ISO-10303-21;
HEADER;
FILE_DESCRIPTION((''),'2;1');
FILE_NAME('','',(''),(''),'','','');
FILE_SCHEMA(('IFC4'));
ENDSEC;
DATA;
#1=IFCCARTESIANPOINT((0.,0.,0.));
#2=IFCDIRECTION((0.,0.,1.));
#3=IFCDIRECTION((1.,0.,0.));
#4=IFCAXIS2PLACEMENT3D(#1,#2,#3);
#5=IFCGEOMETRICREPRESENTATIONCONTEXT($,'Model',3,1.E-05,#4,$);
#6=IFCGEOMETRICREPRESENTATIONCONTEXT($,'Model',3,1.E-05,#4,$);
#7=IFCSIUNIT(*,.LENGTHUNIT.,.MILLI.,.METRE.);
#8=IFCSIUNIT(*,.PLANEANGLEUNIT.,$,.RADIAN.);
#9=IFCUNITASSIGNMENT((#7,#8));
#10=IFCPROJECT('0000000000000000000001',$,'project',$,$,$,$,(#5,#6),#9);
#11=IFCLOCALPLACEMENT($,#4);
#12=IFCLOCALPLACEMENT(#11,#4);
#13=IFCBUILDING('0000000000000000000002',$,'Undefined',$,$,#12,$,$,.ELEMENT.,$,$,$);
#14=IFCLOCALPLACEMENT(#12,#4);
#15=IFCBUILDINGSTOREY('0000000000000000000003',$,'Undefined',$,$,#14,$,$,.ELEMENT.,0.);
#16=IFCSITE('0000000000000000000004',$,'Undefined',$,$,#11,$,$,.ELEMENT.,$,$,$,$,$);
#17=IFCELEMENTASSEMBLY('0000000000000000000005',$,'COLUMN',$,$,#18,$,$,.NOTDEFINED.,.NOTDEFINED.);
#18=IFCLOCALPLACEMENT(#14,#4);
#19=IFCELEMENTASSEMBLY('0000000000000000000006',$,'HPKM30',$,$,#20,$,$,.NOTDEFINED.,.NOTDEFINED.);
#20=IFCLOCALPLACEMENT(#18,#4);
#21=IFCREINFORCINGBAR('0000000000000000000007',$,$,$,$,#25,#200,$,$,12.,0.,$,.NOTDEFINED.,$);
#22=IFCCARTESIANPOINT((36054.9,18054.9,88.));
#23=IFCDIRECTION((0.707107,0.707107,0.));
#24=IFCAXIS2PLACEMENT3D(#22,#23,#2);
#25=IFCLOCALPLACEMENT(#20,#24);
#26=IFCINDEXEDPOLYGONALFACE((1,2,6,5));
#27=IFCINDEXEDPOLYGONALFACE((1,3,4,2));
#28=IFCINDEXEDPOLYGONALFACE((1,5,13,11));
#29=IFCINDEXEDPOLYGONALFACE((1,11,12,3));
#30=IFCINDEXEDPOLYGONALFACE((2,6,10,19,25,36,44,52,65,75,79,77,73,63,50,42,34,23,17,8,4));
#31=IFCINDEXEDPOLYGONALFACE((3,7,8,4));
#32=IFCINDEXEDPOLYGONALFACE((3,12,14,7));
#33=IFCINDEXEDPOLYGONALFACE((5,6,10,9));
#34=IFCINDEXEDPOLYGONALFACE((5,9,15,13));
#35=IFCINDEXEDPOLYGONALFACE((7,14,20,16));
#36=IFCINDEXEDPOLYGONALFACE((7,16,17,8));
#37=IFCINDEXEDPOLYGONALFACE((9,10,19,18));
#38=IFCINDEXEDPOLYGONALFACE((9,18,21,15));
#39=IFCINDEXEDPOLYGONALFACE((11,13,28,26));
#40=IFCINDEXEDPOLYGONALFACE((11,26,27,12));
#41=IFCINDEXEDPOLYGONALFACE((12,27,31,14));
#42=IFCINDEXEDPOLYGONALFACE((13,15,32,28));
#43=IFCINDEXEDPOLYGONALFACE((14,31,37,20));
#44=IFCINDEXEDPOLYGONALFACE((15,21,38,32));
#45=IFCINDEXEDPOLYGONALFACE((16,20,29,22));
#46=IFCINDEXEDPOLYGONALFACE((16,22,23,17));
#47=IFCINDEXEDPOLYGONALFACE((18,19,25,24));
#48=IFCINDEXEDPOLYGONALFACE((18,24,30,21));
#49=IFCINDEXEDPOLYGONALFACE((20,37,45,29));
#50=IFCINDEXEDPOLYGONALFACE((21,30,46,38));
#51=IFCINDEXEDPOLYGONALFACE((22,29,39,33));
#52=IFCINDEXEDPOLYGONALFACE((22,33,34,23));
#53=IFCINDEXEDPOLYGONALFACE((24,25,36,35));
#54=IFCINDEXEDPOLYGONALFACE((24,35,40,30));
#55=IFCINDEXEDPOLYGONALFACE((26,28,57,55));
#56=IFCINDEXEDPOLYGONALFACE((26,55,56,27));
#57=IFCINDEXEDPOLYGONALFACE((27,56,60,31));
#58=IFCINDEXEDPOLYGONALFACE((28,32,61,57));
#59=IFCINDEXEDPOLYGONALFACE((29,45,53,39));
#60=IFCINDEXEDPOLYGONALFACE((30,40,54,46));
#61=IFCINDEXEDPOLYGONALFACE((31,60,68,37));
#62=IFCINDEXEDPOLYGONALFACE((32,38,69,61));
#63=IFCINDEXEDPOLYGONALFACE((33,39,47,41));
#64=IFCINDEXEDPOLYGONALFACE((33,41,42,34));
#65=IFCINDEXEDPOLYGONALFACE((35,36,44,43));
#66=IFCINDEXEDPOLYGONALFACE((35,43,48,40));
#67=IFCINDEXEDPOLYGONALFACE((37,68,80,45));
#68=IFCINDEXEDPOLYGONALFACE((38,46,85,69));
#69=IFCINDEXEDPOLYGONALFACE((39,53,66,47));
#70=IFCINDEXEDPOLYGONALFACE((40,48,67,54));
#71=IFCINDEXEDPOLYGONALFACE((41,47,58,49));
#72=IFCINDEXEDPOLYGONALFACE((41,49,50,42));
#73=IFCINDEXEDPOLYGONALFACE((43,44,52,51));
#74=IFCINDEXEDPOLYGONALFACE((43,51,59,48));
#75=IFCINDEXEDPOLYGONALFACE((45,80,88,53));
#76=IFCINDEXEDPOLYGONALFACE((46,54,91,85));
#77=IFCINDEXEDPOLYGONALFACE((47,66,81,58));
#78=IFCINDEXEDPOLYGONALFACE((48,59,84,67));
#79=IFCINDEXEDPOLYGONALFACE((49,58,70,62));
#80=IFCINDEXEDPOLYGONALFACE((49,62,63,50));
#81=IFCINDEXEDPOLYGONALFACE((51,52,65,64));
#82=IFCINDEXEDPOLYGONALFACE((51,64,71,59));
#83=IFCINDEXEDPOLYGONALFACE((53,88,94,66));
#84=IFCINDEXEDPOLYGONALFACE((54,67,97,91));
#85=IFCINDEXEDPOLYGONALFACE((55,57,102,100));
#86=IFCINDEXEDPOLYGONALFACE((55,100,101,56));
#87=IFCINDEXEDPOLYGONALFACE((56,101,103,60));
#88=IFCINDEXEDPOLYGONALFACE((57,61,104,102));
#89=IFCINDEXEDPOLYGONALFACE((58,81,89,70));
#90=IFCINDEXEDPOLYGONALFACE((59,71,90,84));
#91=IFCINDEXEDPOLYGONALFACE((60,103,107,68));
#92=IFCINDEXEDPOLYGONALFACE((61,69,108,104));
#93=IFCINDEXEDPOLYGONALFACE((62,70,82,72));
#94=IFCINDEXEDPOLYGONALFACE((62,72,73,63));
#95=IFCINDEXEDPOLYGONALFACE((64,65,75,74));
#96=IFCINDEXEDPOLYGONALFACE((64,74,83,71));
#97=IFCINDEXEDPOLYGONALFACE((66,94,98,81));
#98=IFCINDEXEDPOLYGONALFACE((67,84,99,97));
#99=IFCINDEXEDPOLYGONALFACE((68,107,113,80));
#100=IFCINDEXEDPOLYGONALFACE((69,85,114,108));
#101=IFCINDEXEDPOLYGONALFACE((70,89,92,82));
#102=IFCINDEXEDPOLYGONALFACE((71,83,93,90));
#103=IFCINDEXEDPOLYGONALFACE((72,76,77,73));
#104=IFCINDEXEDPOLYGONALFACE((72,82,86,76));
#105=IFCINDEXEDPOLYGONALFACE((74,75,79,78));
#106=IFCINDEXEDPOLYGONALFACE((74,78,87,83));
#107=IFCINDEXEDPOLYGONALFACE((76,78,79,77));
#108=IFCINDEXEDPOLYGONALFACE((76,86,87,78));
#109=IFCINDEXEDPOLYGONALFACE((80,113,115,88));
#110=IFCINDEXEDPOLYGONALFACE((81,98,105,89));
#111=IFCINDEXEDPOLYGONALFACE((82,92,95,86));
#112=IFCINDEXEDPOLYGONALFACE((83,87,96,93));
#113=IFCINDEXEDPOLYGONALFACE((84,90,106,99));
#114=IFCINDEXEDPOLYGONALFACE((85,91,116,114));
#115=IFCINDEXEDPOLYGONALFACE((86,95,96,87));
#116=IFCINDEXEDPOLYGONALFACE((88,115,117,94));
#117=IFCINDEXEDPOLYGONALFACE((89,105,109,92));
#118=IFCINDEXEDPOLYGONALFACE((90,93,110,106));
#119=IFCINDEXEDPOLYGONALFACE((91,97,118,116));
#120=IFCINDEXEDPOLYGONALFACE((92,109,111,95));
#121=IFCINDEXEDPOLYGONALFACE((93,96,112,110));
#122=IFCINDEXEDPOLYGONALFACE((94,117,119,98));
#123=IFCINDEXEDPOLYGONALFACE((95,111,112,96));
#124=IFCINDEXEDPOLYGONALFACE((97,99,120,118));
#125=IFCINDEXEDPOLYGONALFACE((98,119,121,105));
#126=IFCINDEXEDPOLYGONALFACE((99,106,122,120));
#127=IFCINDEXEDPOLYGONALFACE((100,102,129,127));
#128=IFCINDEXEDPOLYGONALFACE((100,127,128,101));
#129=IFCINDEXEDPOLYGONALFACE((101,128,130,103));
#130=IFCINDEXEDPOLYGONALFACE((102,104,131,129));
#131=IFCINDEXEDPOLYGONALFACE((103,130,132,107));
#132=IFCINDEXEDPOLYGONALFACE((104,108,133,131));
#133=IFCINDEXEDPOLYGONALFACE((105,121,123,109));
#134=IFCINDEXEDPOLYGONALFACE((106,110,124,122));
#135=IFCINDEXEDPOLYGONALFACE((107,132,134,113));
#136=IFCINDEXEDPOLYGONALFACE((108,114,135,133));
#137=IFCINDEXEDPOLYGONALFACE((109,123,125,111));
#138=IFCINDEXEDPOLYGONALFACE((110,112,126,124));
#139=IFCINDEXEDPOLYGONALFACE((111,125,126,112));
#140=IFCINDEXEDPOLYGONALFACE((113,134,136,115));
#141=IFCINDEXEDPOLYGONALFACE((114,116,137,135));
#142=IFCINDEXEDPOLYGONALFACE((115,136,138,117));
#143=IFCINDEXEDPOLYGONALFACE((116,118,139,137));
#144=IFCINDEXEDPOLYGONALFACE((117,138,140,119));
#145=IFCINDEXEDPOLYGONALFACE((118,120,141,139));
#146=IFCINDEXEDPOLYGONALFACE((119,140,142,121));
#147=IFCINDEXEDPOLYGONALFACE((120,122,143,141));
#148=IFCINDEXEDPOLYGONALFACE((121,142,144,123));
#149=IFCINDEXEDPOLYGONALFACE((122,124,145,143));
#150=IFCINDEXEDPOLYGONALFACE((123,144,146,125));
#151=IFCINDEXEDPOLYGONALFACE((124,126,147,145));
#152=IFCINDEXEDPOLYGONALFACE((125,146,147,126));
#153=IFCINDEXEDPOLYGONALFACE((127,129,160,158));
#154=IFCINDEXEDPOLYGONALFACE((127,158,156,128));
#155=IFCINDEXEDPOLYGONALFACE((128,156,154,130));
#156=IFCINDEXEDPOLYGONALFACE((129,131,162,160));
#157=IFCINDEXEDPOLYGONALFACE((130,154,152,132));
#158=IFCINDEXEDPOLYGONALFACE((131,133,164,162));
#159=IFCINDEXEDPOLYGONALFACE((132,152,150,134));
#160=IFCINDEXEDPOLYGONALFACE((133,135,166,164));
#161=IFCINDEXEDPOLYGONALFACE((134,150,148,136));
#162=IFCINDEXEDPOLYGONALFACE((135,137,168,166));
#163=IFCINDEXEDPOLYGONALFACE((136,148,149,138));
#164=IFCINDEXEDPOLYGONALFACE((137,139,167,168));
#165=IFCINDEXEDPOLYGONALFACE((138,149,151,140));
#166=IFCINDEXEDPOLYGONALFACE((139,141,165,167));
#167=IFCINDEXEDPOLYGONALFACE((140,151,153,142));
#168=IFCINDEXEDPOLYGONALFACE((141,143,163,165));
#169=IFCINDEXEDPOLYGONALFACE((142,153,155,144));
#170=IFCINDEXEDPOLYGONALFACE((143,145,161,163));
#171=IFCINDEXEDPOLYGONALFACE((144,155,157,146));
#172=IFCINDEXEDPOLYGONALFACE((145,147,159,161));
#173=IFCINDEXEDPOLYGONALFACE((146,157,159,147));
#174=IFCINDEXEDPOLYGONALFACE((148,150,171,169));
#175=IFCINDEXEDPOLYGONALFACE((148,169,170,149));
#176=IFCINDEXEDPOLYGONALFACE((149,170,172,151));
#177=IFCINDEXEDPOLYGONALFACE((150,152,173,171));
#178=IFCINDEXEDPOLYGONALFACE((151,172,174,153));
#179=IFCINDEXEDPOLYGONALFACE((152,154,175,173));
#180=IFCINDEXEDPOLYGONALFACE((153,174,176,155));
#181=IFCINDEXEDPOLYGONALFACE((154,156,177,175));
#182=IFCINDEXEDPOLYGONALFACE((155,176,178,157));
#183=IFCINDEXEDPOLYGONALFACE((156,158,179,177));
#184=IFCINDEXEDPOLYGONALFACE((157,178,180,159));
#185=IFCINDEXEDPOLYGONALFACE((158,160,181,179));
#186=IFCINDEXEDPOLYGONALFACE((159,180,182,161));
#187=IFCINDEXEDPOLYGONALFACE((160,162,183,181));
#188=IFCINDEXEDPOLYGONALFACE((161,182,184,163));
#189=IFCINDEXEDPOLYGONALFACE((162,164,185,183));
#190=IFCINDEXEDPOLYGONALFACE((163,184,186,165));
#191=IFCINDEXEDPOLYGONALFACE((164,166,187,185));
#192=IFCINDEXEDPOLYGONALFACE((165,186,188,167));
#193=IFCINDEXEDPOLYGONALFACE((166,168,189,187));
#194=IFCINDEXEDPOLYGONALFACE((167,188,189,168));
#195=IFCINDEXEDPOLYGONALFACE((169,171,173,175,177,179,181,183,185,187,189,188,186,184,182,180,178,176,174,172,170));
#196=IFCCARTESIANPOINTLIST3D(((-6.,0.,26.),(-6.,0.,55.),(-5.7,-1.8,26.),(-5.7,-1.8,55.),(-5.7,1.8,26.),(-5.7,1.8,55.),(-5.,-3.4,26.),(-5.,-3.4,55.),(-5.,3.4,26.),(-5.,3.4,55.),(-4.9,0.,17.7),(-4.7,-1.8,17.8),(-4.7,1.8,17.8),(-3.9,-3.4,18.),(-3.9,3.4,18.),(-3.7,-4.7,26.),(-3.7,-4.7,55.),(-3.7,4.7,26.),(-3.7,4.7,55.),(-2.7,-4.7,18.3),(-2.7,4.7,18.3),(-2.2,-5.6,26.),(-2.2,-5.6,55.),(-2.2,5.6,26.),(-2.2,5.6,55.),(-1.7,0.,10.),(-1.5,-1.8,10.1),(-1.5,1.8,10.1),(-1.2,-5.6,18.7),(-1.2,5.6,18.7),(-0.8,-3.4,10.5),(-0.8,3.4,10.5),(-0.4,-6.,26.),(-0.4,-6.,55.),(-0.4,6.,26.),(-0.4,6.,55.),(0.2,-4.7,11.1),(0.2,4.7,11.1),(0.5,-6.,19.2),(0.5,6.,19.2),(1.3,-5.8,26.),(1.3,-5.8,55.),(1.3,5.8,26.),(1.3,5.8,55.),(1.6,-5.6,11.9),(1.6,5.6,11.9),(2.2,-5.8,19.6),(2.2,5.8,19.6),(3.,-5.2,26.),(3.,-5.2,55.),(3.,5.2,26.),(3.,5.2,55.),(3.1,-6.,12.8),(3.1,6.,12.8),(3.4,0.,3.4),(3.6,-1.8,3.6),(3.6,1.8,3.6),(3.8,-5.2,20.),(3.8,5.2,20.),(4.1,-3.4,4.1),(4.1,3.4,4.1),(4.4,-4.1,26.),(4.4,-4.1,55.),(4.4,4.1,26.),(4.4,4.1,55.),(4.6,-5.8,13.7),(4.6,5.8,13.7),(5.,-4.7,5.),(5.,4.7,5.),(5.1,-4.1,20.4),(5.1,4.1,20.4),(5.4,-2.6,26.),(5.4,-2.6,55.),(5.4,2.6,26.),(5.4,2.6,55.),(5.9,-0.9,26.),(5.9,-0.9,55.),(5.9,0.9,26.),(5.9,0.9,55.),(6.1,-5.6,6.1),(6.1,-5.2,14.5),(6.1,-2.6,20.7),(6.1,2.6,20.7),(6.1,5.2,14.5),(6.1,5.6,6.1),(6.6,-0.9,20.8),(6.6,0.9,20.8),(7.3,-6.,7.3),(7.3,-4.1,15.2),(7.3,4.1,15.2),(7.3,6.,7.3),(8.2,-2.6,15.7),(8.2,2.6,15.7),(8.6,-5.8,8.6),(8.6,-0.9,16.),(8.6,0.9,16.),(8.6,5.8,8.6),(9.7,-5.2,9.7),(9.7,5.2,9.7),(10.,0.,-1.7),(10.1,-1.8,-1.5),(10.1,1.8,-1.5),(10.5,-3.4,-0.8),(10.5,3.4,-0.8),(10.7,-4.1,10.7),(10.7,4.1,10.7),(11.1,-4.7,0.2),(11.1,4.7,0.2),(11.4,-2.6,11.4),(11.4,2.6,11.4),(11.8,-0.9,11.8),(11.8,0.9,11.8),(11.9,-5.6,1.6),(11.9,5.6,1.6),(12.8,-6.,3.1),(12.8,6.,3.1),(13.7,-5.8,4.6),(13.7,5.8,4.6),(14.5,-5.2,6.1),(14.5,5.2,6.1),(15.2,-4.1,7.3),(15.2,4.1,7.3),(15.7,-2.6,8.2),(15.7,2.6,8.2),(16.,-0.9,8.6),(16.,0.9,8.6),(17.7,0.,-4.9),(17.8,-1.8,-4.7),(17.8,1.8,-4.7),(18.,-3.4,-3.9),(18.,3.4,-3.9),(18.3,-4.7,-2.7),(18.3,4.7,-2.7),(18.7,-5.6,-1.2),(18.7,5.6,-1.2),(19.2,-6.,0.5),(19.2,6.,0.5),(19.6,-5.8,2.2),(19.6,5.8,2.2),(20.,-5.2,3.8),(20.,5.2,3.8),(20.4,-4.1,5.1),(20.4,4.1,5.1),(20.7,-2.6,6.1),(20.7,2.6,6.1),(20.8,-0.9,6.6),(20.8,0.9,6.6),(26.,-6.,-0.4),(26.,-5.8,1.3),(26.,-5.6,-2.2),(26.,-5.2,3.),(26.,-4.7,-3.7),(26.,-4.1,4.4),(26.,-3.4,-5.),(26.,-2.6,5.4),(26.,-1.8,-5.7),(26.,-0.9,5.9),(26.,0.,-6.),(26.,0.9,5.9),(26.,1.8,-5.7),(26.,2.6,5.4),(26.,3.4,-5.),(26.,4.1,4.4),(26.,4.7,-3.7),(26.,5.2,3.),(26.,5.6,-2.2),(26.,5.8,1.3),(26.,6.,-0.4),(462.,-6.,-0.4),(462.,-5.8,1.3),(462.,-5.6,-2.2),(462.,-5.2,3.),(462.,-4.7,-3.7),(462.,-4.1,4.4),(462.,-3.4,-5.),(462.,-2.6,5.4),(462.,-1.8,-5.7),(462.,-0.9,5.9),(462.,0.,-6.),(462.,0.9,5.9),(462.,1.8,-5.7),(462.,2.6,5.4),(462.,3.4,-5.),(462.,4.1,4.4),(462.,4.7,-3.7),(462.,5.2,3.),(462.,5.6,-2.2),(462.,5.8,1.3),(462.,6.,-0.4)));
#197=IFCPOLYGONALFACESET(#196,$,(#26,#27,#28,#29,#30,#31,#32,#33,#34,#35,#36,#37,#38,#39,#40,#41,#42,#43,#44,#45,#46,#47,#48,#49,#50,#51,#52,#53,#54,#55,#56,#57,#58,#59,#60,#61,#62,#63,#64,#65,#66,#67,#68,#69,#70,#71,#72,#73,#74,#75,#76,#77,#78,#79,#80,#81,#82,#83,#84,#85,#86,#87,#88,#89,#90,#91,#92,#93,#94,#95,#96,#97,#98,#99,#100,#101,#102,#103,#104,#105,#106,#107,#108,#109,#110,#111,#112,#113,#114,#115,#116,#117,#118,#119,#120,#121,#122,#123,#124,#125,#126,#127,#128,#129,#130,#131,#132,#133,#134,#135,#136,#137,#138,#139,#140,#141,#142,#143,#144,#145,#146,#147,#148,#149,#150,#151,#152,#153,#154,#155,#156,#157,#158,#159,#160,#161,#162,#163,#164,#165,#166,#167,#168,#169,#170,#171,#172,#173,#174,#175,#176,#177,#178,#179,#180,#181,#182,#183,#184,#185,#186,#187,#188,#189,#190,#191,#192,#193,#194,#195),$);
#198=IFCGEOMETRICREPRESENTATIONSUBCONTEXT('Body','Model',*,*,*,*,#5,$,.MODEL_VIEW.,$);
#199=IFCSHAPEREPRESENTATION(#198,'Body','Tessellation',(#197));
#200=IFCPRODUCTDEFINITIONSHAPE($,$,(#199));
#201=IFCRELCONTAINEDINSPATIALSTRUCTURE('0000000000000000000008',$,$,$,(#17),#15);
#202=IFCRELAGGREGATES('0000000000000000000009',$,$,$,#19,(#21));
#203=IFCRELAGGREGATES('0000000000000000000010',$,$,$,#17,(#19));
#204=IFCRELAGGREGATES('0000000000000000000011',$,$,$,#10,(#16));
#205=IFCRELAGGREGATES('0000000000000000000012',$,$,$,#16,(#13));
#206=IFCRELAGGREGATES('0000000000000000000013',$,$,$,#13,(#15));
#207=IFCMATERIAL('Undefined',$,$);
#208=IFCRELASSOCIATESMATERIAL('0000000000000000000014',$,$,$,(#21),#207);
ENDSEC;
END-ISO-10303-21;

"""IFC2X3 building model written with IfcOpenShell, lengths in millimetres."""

from ifc_helpers import new_model, entity, si_unit, frame, origin_with_axes, place, context, subcontext, project, spatial, source, transform, mapped, material, element, aggregate, save


model = new_model("IFC2X3")

# Units and contexts
model_context_1 = context("Model", 3, precision=1e-05, world=origin_with_axes())
model_context_2 = context("Model", 3, precision=1e-05, world=origin_with_axes())
body_context = subcontext(model_context_1, "Body", "Model", "MODEL_VIEW")
ifc_project = project(units=[si_unit("LENGTHUNIT", "METRE", prefix="MILLI"), si_unit("PLANEANGLEUNIT", "RADIAN")], contexts=[model_context_1, model_context_2])

# Site, building, storey
site_placement = place(None, origin_with_axes())
site = spatial("IfcSite", under=ifc_project, at=site_placement, Name="Undefined", CompositionType="ELEMENT")
building_placement = place(site_placement, origin_with_axes())
building = spatial("IfcBuilding", under=site, at=building_placement, Name="Undefined", CompositionType="ELEMENT")
storey_placement = place(building_placement, origin_with_axes())
storey = spatial("IfcBuildingStorey", under=building, at=storey_placement, Name="Undefined", CompositionType="ELEMENT", Elevation=0.0)

# Element assembly
assembly_1_placement = place(storey_placement, origin_with_axes())
assembly_1 = element("IfcElementAssembly", 1, at=assembly_1_placement, inside=storey, Name="COLUMN", AssemblyPlace="NOTDEFINED", PredefinedType="NOTDEFINED")

# Element assembly
assembly_2_placement = place(assembly_1_placement, origin_with_axes())
assembly_2 = element("IfcElementAssembly", 2, at=assembly_2_placement, Name="HPKM30", AssemblyPlace="NOTDEFINED", PredefinedType="NOTDEFINED")

# Shared definitions
ifc_material_1 = material(Name="Undefined")

# Reinforcing bar
shared_shape_1 = source(origin_with_axes(), body_context, "Body", "AdvancedSweptSolid", [
    entity("IfcSweptDiskSolid", entity("IfcCompositeCurve", [entity("IfcCompositeCurveSegment", "CONTINUOUS", True, entity("IfcTrimmedCurve", entity("IfcLine", entity("IfcCartesianPoint", [0.0, 0.0, 0.0]), entity("IfcVector", entity("IfcDirection", [0.0, 0.0, -1.0]), 1.0)), [entity("IfcParameterValue", 0.0)], [entity("IfcParameterValue", 29.0)], True, "PARAMETER")), entity("IfcCompositeCurveSegment", "CONTINUOUS", True, entity("IfcTrimmedCurve", entity("IfcCircle", entity("IfcAxis2Placement3D", entity("IfcCartesianPoint", [26.0, 0.0, -29.0]), entity("IfcDirection", [0.0, -1.0, 0.0]), entity("IfcDirection", [-1.0, 0.0, 0.0])), 26.0), [entity("IfcParameterValue", 0.0)], [entity("IfcParameterValue", 1.570796)], True, "PARAMETER")), entity("IfcCompositeCurveSegment", "DISCONTINUOUS", True, entity("IfcTrimmedCurve", entity("IfcLine", entity("IfcCartesianPoint", [26.0, 0.0, -55.0]), entity("IfcVector", entity("IfcDirection", [1.0, 0.0, 0.0]), 1.0)), [entity("IfcParameterValue", 0.0)], [entity("IfcParameterValue", 436.0)], True, "PARAMETER"))], False), 6.0, None, 0.0, 466.6),
])
reinforcing_bar_1_placement = place(assembly_2_placement, frame((36054.9, 18054.9, 88.0), z_axis=(0.707107, 0.707107, 0.0), x_axis=(0.0, 0.0, 1.0)))
reinforcing_bar_1 = element("IfcReinforcingBar", 3, at=reinforcing_bar_1_placement, material=ifc_material_1, BarRole="NOTDEFINED", CrossSectionArea=0.0, NominalDiameter=12.0, context=body_context, shape_type="MappedRepresentation", body=[
    mapped(shared_shape_1, transform((0.0, 0.0, 55.0))),
])
aggregate(assembly_2, [reinforcing_bar_1])
aggregate(assembly_1, [assembly_2])

save(model, "model.ifc")
